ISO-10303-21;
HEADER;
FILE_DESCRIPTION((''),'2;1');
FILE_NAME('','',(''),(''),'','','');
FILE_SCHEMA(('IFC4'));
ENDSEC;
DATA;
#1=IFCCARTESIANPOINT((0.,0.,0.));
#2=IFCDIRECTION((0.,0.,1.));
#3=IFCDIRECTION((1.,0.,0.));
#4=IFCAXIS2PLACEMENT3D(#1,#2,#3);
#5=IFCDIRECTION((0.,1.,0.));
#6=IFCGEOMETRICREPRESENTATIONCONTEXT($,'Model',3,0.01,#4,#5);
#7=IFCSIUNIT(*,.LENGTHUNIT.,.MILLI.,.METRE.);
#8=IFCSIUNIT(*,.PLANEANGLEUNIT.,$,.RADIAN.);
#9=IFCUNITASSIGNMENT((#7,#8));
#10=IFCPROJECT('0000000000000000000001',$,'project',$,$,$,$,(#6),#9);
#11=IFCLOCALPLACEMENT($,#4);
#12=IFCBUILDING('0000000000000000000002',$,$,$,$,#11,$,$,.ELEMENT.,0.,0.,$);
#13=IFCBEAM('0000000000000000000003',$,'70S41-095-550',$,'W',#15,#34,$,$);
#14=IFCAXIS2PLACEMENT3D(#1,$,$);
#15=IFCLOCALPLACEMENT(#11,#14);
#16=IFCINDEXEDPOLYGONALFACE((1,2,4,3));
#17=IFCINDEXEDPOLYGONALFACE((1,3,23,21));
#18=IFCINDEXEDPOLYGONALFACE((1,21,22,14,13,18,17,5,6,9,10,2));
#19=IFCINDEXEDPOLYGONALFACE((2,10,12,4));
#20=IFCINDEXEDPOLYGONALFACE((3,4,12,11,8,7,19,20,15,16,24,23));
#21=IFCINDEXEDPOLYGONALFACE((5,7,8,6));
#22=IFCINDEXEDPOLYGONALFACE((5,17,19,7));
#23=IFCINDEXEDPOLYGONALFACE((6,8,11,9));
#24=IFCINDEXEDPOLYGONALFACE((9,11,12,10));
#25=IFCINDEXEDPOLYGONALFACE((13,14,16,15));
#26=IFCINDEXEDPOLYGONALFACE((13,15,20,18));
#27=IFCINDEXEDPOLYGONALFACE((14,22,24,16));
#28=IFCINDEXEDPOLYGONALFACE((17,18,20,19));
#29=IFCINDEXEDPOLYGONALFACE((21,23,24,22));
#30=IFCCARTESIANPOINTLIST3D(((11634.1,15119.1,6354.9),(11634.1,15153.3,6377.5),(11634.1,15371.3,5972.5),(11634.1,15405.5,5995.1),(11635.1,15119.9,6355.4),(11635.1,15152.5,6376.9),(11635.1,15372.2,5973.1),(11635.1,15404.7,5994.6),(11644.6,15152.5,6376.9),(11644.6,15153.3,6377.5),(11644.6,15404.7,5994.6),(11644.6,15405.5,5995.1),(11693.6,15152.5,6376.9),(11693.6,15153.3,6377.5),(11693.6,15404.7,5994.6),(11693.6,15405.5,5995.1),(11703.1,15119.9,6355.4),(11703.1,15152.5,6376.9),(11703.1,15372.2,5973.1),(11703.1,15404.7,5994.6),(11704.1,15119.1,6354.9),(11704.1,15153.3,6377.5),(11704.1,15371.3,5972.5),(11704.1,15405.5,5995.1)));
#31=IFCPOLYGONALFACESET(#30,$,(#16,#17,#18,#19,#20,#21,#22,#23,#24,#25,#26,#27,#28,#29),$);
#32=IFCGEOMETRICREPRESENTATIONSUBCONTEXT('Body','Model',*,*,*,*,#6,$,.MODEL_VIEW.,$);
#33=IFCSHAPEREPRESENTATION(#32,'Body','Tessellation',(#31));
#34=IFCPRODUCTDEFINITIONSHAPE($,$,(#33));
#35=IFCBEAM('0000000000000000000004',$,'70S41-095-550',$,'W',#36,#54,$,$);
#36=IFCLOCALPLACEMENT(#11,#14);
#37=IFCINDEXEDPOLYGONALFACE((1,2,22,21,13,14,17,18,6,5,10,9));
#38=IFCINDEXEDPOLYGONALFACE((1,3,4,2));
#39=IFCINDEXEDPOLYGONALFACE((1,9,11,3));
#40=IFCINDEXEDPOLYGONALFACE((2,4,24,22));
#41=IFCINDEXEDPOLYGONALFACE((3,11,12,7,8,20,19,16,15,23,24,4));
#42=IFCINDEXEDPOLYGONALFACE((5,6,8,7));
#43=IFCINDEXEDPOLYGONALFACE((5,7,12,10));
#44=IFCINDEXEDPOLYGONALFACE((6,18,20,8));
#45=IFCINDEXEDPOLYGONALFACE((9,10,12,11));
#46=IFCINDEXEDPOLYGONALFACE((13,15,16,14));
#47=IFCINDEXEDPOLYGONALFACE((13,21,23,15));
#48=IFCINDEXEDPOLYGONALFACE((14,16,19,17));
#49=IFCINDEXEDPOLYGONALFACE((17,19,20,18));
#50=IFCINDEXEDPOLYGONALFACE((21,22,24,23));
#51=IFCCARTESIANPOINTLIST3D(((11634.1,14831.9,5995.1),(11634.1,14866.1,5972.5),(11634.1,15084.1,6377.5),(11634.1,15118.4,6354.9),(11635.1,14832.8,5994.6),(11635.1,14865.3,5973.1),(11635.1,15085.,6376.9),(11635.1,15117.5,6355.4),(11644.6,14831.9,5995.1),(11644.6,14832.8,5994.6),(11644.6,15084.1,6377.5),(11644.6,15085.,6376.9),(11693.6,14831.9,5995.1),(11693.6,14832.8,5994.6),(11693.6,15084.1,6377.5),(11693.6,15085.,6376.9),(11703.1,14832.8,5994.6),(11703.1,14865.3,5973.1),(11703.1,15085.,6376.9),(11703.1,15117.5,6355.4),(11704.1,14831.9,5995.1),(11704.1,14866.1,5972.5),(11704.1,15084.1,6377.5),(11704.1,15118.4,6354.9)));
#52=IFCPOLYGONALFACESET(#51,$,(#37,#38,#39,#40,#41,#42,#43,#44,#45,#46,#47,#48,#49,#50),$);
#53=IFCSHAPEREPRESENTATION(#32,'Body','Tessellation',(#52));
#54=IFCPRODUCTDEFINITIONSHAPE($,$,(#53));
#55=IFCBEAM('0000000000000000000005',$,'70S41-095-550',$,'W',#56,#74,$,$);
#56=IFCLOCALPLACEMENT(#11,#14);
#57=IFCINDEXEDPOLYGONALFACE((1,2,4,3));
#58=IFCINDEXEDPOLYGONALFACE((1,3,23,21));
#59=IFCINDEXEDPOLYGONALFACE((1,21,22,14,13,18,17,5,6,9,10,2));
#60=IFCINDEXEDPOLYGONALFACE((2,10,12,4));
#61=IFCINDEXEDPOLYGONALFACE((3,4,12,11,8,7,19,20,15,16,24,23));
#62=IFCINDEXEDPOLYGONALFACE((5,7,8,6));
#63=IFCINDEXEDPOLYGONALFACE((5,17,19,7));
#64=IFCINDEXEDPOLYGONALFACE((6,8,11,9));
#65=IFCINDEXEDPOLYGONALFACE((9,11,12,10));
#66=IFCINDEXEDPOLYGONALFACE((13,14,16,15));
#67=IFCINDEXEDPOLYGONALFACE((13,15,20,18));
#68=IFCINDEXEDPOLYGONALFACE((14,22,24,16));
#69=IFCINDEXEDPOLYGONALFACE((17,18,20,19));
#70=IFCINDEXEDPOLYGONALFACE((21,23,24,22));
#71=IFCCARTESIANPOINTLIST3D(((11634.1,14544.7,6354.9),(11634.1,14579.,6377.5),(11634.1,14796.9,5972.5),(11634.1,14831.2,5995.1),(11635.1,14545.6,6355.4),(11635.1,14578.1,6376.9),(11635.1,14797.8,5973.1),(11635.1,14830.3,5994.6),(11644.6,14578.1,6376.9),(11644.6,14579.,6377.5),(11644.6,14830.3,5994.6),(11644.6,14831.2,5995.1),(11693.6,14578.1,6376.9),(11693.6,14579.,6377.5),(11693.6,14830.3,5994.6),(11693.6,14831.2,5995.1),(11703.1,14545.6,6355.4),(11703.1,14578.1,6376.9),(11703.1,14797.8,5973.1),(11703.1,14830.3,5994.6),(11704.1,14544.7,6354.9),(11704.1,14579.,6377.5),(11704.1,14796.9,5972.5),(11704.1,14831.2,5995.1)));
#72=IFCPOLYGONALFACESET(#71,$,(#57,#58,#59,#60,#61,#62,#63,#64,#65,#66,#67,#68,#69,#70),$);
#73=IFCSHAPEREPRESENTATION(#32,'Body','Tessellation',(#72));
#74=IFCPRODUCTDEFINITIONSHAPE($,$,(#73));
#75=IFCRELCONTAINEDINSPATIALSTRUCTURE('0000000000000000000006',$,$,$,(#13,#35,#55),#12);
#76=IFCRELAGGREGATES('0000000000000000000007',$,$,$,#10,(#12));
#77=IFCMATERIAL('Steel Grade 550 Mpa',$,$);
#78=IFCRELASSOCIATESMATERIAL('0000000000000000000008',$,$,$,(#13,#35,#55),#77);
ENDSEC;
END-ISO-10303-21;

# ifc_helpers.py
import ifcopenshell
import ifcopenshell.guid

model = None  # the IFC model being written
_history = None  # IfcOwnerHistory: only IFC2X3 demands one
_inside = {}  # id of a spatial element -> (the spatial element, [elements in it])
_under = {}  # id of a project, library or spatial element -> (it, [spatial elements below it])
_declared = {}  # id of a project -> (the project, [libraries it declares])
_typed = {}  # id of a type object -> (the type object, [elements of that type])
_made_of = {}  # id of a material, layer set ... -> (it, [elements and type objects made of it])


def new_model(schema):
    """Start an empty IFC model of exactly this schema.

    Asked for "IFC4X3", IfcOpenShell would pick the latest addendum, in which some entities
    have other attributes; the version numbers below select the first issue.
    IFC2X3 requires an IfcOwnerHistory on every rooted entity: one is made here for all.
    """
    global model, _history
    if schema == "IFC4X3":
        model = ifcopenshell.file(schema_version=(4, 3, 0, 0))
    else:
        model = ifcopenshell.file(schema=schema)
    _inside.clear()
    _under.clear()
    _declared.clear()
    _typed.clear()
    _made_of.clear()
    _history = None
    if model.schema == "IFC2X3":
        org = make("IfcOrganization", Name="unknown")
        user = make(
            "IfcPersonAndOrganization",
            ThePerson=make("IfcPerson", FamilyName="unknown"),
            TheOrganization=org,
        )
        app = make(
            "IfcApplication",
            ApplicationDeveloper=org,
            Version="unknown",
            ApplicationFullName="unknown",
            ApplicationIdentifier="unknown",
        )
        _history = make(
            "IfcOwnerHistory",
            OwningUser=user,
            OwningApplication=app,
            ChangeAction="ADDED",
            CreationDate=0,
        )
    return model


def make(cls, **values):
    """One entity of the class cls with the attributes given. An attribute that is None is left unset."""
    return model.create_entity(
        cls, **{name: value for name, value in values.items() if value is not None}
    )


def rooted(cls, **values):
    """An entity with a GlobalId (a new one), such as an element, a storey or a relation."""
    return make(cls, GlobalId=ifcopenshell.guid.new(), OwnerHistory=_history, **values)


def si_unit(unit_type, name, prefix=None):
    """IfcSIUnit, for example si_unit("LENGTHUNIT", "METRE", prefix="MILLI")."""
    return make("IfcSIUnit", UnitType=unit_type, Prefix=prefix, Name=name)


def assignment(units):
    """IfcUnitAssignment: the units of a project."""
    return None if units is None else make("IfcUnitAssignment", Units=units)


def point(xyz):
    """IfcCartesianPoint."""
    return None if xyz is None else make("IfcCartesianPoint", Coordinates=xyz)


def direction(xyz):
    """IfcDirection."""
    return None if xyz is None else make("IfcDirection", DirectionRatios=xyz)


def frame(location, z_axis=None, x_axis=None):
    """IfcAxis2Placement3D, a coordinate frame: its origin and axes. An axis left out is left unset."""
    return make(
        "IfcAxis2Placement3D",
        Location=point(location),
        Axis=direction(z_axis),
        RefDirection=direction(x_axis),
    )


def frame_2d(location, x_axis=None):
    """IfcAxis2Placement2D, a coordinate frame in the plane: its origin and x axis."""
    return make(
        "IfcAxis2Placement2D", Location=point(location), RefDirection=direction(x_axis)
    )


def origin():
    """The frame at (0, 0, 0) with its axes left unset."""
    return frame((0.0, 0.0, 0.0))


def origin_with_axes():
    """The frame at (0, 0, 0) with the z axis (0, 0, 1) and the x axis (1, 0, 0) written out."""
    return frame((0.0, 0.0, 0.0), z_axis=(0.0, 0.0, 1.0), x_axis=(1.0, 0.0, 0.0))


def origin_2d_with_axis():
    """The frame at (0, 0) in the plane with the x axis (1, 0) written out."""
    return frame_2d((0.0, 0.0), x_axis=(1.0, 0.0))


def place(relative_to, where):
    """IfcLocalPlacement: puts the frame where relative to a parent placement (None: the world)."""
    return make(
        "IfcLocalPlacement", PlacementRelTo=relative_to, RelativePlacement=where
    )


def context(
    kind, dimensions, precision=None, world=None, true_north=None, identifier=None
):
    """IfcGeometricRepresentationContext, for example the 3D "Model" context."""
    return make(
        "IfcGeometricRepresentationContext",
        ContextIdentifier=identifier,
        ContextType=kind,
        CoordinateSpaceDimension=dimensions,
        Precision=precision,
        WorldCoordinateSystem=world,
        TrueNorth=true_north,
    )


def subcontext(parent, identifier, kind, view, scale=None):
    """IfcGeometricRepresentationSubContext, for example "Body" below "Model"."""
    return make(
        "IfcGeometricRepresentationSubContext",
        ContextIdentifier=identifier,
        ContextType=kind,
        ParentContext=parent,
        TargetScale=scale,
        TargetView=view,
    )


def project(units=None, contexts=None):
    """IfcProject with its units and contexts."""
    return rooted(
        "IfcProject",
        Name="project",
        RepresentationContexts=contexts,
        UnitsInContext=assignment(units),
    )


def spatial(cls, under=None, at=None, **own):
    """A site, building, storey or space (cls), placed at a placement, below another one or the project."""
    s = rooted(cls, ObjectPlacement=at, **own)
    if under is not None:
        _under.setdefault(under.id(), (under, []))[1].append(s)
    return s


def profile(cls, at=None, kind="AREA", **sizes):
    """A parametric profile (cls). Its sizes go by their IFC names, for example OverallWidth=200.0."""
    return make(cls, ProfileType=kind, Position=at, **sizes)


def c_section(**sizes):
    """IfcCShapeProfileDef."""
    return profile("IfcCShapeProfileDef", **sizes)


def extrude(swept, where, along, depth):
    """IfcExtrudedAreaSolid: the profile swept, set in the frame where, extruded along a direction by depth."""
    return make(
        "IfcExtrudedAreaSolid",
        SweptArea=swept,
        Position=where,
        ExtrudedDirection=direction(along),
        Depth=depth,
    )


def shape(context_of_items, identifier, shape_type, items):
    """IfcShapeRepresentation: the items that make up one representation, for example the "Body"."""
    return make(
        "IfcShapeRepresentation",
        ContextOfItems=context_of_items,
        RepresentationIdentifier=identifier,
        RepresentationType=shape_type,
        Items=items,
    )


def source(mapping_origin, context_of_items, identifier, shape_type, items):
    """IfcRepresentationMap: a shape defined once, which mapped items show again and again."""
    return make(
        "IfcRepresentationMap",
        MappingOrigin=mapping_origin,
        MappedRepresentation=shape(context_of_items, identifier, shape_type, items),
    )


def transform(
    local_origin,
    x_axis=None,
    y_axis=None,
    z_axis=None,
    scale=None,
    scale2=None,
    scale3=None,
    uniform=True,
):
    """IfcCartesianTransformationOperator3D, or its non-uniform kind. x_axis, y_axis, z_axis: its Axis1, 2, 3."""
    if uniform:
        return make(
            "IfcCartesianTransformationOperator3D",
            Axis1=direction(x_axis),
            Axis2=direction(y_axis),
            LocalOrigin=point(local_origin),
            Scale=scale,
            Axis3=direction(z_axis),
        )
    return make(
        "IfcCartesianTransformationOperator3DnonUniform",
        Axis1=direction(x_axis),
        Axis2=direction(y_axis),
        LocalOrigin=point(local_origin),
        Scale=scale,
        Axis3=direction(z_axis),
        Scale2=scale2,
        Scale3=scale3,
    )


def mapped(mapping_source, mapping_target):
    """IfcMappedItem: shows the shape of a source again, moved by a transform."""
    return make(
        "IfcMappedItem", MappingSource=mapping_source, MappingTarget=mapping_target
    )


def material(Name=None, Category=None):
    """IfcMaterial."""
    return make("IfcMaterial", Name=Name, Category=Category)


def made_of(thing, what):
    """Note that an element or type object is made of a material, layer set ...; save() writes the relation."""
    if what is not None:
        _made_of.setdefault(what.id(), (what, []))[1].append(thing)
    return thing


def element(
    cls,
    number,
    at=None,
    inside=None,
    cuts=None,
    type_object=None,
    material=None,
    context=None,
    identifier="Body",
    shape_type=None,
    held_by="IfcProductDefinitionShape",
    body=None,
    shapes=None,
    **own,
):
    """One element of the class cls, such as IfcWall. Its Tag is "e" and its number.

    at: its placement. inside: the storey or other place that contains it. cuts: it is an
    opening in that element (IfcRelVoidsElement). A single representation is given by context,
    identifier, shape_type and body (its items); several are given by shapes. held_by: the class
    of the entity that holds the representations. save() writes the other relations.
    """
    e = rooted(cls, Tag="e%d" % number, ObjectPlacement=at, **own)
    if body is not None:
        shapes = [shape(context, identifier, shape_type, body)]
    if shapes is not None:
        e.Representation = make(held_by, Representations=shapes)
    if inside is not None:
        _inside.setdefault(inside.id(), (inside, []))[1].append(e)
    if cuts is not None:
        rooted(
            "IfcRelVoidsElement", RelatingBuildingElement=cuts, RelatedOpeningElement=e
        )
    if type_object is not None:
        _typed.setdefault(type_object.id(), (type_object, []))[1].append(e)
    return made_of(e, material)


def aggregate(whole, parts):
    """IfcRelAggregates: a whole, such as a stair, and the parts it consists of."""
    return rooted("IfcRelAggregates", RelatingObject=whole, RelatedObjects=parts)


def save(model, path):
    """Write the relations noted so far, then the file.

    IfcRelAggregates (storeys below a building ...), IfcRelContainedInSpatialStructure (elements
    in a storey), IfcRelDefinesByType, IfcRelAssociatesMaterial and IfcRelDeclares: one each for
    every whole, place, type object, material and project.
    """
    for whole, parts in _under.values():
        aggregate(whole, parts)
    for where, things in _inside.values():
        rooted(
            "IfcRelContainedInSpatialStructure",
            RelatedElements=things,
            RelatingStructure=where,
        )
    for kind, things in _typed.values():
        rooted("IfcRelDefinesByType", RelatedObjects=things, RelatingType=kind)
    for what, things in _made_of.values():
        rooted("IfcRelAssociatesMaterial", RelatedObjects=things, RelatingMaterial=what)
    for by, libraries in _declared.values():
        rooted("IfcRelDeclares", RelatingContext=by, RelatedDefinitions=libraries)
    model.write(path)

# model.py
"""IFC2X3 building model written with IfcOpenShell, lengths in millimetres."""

from ifc_helpers import new_model, si_unit, direction, frame, origin, origin_with_axes, origin_2d_with_axis, place, context, subcontext, project, spatial, c_section, extrude, source, transform, mapped, material, element, save


model = new_model("IFC2X3")

# Units and contexts
model_context = context("Model", 3, precision=0.01, world=origin_with_axes(), true_north=direction((0.0, 1.0, 0.0)))
body_context = subcontext(model_context, "Body", "Model", "MODEL_VIEW")
ifc_project = project(units=[si_unit("LENGTHUNIT", "METRE", prefix="MILLI"), si_unit("PLANEANGLEUNIT", "RADIAN")], contexts=[model_context])

# Building
building_placement = place(None, origin_with_axes())
building = spatial("IfcBuilding", under=ifc_project, at=building_placement, CompositionType="ELEMENT", ElevationOfRefHeight=0.0, ElevationOfTerrain=0.0)

# Beams
ifc_material = material(Name="Steel Grade 550 Mpa")
shared_shape_1 = source(origin(), body_context, "Body", "SweptSolid", [
    extrude(c_section(Depth=70.0, Width=41.0, WallThickness=1.0, Girth=10.5, at=origin_2d_with_axis()), origin_with_axes(), (0.0, 0.0, 1.0), 458.1),
])
beam_1_placement = place(None, frame((11669.1, 15136.2, 6366.2), z_axis=(0.0, 0.550611, -0.834762), x_axis=(0.0, 0.834762, 0.550611)))
element("IfcBeam", 1, at=beam_1_placement, inside=building, material=ifc_material, Name="70S41-095-550", ObjectType="W", context=body_context, shape_type="MappedRepresentation", body=[
    mapped(shared_shape_1, transform((0.0, 0.0, 0.0), scale=1.0)),
])
shared_shape_2 = source(origin(), body_context, "Body", "SweptSolid", [
    extrude(c_section(Depth=70.0, Width=41.0, WallThickness=1.0, Girth=10.5, at=origin_2d_with_axis()), origin_with_axes(), (0.0, 0.0, 1.0), 458.1),
])
beam_2_placement = place(None, frame((11669.1, 14849.0, 5983.8), z_axis=(0.0, 0.550611, 0.834762), x_axis=(0.0, -0.834762, 0.550611)))
element("IfcBeam", 2, at=beam_2_placement, inside=building, material=ifc_material, Name="70S41-095-550", ObjectType="W", context=body_context, shape_type="MappedRepresentation", body=[
    mapped(shared_shape_2, transform((0.0, 0.0, 0.0), scale=1.0)),
])
shared_shape_3 = source(origin(), body_context, "Body", "SweptSolid", [
    extrude(c_section(Depth=70.0, Width=41.0, WallThickness=1.0, Girth=10.5, at=origin_2d_with_axis()), origin_with_axes(), (0.0, 0.0, 1.0), 458.1),
])
beam_3_placement = place(None, frame((11669.1, 14561.8, 6366.2), z_axis=(0.0, 0.550611, -0.834762), x_axis=(0.0, 0.834762, 0.550611)))
element("IfcBeam", 3, at=beam_3_placement, inside=building, material=ifc_material, Name="70S41-095-550", ObjectType="W", context=body_context, shape_type="MappedRepresentation", body=[
    mapped(shared_shape_3, transform((0.0, 0.0, 0.0), scale=1.0)),
])

save(model, "model.ifc")
